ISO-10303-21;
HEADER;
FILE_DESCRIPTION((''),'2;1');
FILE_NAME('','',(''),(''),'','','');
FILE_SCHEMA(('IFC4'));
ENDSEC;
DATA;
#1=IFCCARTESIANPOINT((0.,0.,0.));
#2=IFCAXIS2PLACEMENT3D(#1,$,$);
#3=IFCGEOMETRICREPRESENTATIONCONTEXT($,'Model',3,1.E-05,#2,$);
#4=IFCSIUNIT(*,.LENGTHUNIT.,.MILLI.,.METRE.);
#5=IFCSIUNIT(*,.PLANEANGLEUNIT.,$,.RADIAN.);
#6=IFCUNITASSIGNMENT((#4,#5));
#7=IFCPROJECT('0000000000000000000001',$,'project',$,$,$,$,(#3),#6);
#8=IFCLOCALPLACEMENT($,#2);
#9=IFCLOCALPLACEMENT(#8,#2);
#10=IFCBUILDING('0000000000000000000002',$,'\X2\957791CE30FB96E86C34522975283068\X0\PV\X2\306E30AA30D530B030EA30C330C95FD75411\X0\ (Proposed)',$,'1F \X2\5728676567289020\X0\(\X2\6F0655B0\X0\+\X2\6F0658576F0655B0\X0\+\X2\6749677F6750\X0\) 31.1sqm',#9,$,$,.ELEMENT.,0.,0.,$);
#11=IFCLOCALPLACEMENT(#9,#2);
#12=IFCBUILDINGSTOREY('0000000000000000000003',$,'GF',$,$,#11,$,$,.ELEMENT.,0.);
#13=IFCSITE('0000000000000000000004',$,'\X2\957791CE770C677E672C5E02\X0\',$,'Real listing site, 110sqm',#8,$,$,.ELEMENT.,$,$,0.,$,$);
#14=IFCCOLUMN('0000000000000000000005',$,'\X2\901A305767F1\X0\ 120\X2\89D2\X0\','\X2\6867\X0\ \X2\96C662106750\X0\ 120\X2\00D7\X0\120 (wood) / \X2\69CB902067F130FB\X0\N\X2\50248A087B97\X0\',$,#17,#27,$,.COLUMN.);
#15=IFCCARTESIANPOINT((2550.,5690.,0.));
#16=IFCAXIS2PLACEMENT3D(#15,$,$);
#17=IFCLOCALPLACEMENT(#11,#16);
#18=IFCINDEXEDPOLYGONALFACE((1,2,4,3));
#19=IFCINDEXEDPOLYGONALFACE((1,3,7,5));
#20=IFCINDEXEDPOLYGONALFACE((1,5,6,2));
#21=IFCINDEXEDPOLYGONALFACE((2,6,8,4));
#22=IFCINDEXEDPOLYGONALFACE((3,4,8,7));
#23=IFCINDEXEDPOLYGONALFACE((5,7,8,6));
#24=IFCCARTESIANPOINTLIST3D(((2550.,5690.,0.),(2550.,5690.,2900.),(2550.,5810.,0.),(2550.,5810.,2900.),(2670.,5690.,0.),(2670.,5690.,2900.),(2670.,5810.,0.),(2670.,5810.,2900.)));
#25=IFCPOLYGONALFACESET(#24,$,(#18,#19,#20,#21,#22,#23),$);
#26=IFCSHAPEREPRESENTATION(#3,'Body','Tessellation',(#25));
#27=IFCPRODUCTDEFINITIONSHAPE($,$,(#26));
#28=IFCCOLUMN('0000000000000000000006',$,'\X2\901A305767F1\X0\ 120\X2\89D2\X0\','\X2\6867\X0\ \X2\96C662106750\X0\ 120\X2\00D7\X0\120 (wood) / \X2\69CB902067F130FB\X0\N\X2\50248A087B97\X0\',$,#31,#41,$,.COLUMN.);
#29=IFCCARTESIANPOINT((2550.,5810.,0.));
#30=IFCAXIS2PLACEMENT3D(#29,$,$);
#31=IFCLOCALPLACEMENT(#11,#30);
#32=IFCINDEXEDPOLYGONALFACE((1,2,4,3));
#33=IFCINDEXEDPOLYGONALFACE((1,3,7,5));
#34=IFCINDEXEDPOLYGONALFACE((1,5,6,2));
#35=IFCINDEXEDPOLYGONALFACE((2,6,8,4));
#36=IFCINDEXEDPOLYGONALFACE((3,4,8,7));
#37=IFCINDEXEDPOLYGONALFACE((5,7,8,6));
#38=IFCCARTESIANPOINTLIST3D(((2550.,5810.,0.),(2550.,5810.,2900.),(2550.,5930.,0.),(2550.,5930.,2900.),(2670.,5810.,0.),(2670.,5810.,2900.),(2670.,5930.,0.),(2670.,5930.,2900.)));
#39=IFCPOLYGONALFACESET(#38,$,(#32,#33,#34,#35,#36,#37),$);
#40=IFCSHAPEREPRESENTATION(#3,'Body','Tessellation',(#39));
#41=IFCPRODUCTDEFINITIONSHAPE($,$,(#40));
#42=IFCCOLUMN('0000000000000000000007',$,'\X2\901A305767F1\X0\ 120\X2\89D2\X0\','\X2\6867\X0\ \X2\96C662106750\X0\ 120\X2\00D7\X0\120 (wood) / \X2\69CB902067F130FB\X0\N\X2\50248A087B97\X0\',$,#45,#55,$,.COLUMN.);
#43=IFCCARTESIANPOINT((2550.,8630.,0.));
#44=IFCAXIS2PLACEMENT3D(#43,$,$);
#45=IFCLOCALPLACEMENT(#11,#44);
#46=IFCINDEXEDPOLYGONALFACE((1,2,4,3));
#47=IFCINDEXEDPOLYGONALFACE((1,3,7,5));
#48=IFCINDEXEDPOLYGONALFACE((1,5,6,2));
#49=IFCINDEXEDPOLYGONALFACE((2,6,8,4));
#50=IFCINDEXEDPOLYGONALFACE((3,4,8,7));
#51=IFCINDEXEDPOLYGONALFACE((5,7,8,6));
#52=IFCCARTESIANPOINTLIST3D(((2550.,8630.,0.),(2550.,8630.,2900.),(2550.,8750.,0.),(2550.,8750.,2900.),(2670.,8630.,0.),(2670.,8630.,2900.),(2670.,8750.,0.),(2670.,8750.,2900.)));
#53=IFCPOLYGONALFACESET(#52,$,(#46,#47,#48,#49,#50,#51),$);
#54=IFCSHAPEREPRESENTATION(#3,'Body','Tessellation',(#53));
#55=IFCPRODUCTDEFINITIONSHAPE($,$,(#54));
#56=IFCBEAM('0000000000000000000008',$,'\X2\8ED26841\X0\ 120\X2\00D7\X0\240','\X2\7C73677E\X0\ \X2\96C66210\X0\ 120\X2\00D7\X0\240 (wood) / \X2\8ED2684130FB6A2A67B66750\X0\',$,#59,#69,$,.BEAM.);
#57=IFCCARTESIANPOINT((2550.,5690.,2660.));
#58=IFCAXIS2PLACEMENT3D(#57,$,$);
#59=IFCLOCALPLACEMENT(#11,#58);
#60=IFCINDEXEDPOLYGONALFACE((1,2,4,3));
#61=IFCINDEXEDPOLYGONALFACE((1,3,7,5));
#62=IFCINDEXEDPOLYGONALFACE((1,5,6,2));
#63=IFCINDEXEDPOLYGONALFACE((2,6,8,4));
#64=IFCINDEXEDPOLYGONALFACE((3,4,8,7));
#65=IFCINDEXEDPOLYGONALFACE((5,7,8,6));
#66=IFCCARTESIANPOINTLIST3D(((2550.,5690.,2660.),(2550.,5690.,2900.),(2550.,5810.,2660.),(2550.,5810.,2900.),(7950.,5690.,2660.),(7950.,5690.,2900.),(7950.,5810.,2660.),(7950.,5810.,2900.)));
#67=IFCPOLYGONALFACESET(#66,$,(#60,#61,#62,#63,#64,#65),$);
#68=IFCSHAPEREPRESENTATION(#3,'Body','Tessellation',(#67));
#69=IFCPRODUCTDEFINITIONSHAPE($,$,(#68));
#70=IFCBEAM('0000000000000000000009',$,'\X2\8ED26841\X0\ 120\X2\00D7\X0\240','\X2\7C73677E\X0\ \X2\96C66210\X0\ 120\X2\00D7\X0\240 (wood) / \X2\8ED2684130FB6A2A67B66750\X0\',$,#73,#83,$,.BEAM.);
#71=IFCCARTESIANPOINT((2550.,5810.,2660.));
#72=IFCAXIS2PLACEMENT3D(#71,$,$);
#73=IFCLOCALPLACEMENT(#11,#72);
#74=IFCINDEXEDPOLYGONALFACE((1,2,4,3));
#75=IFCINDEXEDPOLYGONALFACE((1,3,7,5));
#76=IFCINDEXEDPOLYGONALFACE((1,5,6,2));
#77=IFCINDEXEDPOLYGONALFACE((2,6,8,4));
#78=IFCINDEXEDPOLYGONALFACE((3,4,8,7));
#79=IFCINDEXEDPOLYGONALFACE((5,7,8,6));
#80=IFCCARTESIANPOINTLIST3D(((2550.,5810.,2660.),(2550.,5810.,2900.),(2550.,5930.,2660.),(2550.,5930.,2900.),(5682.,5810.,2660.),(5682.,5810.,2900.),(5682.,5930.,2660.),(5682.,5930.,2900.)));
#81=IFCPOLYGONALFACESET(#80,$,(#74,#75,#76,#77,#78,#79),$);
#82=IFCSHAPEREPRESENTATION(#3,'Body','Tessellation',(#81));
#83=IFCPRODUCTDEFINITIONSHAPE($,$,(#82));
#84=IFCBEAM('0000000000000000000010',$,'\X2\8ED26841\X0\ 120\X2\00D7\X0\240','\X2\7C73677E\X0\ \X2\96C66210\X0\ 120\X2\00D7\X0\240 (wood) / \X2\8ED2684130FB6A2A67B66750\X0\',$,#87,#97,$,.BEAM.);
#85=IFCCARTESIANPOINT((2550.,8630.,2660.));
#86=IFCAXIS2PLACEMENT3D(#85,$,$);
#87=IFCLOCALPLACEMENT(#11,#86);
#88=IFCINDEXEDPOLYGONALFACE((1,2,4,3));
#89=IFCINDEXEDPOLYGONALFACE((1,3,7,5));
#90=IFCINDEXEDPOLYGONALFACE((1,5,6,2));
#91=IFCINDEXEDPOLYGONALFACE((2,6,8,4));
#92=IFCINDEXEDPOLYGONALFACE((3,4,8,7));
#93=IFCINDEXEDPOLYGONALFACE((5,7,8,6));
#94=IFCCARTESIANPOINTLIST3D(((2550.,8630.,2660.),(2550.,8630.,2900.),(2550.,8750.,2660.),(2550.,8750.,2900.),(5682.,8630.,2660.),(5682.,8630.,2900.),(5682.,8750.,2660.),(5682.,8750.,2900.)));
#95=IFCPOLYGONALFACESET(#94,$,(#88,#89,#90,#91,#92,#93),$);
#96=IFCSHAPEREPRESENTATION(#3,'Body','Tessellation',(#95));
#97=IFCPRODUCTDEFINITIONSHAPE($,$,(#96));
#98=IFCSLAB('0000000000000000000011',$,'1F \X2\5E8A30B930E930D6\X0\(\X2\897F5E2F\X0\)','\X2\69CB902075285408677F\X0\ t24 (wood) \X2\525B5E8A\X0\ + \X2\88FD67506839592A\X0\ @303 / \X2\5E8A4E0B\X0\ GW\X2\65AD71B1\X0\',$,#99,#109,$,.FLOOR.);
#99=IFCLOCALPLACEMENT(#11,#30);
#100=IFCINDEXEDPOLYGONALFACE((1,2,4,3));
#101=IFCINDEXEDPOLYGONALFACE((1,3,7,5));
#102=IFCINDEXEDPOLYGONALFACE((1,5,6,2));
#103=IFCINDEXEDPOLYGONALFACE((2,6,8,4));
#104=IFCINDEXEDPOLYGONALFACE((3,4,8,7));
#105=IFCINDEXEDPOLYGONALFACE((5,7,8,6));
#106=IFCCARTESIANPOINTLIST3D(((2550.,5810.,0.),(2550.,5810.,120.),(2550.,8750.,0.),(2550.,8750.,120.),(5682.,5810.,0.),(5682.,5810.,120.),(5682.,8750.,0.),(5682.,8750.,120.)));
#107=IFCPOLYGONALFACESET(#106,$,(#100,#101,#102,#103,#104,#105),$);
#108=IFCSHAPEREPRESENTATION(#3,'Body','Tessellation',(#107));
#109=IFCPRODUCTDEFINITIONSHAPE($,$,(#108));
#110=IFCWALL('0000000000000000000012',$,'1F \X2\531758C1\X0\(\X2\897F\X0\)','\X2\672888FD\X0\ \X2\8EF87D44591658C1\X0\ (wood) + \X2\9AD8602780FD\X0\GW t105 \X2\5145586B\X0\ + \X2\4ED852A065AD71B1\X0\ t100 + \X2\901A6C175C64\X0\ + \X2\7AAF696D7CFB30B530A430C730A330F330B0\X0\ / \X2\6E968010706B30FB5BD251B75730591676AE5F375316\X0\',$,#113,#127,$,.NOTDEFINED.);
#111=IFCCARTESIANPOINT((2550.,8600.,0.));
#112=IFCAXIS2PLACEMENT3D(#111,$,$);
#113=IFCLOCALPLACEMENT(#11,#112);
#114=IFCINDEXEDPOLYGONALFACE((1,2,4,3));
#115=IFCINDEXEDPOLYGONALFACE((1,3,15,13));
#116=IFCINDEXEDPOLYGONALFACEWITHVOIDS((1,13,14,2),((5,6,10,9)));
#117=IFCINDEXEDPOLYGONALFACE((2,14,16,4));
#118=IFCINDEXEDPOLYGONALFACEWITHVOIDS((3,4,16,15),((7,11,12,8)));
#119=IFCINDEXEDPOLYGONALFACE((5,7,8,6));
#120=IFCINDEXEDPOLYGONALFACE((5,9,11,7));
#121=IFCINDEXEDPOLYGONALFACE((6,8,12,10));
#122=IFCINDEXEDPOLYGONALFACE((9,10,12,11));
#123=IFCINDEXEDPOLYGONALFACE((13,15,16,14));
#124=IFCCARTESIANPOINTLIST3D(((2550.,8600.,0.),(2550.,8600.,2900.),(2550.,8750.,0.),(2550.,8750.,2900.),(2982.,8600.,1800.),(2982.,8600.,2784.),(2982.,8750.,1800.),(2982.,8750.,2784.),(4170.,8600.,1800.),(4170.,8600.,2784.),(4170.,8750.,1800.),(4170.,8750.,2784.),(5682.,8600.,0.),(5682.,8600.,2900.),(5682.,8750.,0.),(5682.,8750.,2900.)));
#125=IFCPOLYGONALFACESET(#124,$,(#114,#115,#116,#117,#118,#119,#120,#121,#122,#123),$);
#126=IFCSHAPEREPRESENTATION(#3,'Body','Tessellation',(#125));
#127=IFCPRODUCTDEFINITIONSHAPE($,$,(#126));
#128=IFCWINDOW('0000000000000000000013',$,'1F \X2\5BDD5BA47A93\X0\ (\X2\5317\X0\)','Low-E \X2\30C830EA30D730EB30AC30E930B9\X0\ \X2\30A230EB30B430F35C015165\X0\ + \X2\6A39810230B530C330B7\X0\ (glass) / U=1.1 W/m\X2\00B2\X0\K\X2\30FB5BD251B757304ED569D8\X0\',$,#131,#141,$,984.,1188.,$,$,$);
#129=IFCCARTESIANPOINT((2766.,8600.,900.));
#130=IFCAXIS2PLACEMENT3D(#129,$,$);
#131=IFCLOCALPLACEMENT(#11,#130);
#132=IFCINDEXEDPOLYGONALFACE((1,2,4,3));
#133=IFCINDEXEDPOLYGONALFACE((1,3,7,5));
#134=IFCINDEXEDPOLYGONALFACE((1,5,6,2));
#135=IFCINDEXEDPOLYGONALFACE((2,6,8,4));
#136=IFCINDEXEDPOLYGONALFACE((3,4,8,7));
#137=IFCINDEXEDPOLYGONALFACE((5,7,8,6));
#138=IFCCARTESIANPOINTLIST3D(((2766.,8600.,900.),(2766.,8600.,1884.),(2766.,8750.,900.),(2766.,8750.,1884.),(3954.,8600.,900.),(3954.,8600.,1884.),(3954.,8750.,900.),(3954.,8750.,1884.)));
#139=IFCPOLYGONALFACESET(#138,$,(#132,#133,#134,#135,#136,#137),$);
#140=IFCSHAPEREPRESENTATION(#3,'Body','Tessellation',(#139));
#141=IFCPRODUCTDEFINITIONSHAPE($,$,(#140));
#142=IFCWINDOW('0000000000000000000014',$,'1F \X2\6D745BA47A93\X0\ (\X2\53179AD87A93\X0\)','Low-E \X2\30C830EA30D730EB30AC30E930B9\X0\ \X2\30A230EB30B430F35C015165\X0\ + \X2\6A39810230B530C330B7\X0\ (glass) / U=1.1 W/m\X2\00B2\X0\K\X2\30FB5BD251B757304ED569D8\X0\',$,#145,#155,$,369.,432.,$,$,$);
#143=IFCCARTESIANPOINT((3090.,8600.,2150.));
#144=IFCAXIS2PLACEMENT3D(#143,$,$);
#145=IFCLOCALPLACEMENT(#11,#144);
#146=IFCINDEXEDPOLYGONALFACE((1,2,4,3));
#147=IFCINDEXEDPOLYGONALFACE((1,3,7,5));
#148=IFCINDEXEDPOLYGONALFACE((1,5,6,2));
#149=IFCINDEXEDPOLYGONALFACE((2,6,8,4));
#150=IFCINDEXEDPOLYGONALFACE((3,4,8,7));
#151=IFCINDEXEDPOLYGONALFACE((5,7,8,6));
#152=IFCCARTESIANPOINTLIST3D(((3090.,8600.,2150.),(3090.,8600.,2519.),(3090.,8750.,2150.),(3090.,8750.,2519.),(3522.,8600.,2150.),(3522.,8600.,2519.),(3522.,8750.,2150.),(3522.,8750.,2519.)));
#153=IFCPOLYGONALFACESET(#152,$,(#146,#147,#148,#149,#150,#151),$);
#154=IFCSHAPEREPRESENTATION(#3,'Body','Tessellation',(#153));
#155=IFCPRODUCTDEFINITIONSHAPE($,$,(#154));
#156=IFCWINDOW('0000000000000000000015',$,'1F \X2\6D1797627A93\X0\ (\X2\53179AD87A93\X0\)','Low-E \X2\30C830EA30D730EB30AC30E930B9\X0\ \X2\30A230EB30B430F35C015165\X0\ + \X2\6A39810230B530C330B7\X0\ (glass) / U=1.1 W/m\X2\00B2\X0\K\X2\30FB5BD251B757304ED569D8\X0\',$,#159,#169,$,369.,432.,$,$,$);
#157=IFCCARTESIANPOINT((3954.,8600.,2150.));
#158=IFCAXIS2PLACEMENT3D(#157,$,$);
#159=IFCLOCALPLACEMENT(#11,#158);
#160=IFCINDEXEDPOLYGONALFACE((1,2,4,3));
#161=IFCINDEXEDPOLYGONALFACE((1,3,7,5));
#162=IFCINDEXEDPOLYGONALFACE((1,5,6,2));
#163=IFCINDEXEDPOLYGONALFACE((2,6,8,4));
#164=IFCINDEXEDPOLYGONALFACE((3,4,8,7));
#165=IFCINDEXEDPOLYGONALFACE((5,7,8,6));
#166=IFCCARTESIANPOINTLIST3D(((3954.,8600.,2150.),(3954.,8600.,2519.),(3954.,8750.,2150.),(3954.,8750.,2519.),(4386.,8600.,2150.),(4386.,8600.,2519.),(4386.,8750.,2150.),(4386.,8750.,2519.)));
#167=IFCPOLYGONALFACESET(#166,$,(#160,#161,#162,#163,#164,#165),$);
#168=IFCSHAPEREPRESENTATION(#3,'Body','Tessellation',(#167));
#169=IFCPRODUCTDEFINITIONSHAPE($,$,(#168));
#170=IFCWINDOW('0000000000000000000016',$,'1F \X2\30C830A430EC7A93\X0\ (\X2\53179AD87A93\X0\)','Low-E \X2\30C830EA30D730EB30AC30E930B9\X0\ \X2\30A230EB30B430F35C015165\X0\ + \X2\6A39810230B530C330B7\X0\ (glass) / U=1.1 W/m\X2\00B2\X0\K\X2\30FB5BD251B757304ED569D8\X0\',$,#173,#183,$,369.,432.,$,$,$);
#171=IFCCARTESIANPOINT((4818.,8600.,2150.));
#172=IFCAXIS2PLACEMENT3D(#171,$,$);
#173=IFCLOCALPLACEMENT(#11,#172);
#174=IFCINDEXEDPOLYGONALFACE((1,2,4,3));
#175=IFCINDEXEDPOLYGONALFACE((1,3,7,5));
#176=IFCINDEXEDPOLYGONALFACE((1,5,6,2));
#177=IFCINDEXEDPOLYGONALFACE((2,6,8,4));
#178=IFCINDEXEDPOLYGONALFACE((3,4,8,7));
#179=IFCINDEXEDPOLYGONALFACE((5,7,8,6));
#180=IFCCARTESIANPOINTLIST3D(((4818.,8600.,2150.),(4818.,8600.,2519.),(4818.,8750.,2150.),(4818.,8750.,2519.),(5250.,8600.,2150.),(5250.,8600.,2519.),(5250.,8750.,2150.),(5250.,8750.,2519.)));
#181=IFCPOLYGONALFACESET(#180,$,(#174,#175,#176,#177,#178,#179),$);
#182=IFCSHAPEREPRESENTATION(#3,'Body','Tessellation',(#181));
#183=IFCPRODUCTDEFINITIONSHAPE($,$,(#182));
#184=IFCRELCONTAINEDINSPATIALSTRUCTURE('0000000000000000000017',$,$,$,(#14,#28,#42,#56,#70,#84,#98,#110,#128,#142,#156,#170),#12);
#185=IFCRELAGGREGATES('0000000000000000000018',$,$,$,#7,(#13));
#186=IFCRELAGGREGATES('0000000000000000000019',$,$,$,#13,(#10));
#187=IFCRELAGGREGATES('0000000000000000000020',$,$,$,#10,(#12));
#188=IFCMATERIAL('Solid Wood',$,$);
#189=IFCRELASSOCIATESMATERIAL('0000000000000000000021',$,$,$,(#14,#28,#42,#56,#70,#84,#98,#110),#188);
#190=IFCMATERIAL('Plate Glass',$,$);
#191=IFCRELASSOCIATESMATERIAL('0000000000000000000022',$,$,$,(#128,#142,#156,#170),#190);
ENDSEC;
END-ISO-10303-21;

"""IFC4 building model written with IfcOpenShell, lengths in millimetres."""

from ifc_helpers import new_model, si_unit, frame, frame_2d, origin, place, context, project, spatial, rectangle, extrude, material, element, fill, save


model = new_model("IFC4")

# Units and contexts
model_context = context("Model", 3, precision=1e-05, world=origin())
ifc_project = project(units=[si_unit("LENGTHUNIT", "METRE", prefix="MILLI"), si_unit("PLANEANGLEUNIT", "RADIAN")], contexts=[model_context])

# Site, building, storey
site_placement = place(None, origin())
site = spatial("IfcSite", under=ifc_project, at=site_placement, Name="長野県松本市", ObjectType="Real listing site, 110sqm", CompositionType="ELEMENT", RefElevation=0.0)
building_placement = place(site_placement, origin())
building = spatial("IfcBuilding", under=site, at=building_placement, Name="長野・雨水利用とPVのオフグリッド志向 (Proposed)", ObjectType="1F 在来木造(漆喰+漆塗漆喰+杉板材) 31.1sqm", CompositionType="ELEMENT", ElevationOfRefHeight=0.0, ElevationOfTerrain=0.0)
storey_placement = place(building_placement, origin())
storey = spatial("IfcBuildingStorey", under=building, at=storey_placement, Name="GF", CompositionType="ELEMENT", Elevation=0.0)

# Columns
ifc_material_1 = material(Name="Solid Wood")
column_1_placement = place(storey_placement, frame((2550.0, 5690.0, 0.0)))
element("IfcColumn", 1, at=column_1_placement, inside=storey, material=ifc_material_1, Name="通し柱 120角", Description="桧 集成材 120×120 (wood) / 構造柱・N値計算", PredefinedType="COLUMN", context=model_context, shape_type="SweptSolid", body=[
    extrude(rectangle(XDim=120.0, YDim=120.0, at=frame_2d((60.0, 60.0))), frame((2550.0, 5690.0, 0.0)), (0.0, 0.0, 1.0), 2900.0),
])
column_2_placement = place(storey_placement, frame((2550.0, 5810.0, 0.0)))
element("IfcColumn", 2, at=column_2_placement, inside=storey, material=ifc_material_1, Name="通し柱 120角", Description="桧 集成材 120×120 (wood) / 構造柱・N値計算", PredefinedType="COLUMN", context=model_context, shape_type="SweptSolid", body=[
    extrude(rectangle(XDim=120.0, YDim=120.0, at=frame_2d((60.0, 60.0))), frame((2550.0, 5810.0, 0.0)), (0.0, 0.0, 1.0), 2900.0),
])
column_3_placement = place(storey_placement, frame((2550.0, 8630.0, 0.0)))
element("IfcColumn", 3, at=column_3_placement, inside=storey, material=ifc_material_1, Name="通し柱 120角", Description="桧 集成材 120×120 (wood) / 構造柱・N値計算", PredefinedType="COLUMN", context=model_context, shape_type="SweptSolid", body=[
    extrude(rectangle(XDim=120.0, YDim=120.0, at=frame_2d((60.0, 60.0))), frame((2550.0, 8630.0, 0.0)), (0.0, 0.0, 1.0), 2900.0),
])

# Beams
beam_1_placement = place(storey_placement, frame((2550.0, 5690.0, 2660.0)))
element("IfcBeam", 4, at=beam_1_placement, inside=storey, material=ifc_material_1, Name="軒桁 120×240", Description="米松 集成 120×240 (wood) / 軒桁・横架材", PredefinedType="BEAM", context=model_context, shape_type="SweptSolid", body=[
    extrude(rectangle(XDim=5400.0, YDim=120.0, at=frame_2d((2700.0, 60.0))), frame((2550.0, 5690.0, 2660.0)), (0.0, 0.0, 1.0), 240.0),
])
beam_2_placement = place(storey_placement, frame((2550.0, 5810.0, 2660.0)))
element("IfcBeam", 5, at=beam_2_placement, inside=storey, material=ifc_material_1, Name="軒桁 120×240", Description="米松 集成 120×240 (wood) / 軒桁・横架材", PredefinedType="BEAM", context=model_context, shape_type="SweptSolid", body=[
    extrude(rectangle(XDim=3132.0, YDim=120.0, at=frame_2d((1566.0, 60.0))), frame((2550.0, 5810.0, 2660.0)), (0.0, 0.0, 1.0), 240.0),
])
beam_3_placement = place(storey_placement, frame((2550.0, 8630.0, 2660.0)))
element("IfcBeam", 6, at=beam_3_placement, inside=storey, material=ifc_material_1, Name="軒桁 120×240", Description="米松 集成 120×240 (wood) / 軒桁・横架材", PredefinedType="BEAM", context=model_context, shape_type="SweptSolid", body=[
    extrude(rectangle(XDim=3132.0, YDim=120.0, at=frame_2d((1566.0, 60.0))), frame((2550.0, 8630.0, 2660.0)), (0.0, 0.0, 1.0), 240.0),
])

# Slab
slab_placement = place(storey_placement, frame((2550.0, 5810.0, 0.0)))
element("IfcSlab", 7, at=slab_placement, inside=storey, material=ifc_material_1, Name="1F 床スラブ(西帯)", Description="構造用合板 t24 (wood) 剛床 + 製材根太 @303 / 床下 GW断熱", PredefinedType="FLOOR", context=model_context, shape_type="SweptSolid", body=[
    extrude(rectangle(XDim=3132.0, YDim=2940.0, at=frame_2d((1566.0, 1470.0))), frame((2550.0, 5810.0, 0.0)), (0.0, 0.0, 1.0), 120.0),
])

# Wall, openings, windows
wall_1_placement = place(storey_placement, frame((2550.0, 8600.0, 0.0)))
wall_1 = element("IfcWall", 8, at=wall_1_placement, inside=storey, material=ifc_material_1, Name="1F 北壁(西)", Description="木製 軸組外壁 (wood) + 高性能GW t105 充填 + 付加断熱 t100 + 通気層 + 窯業系サイディング / 準耐火・寒冷地外皮強化", PredefinedType="NOTDEFINED", context=model_context, shape_type="SweptSolid", body=[
    extrude(rectangle(XDim=3132.0, YDim=150.0, at=frame_2d((1566.0, 75.0))), frame((2550.0, 8600.0, 0.0)), (0.0, 0.0, 1.0), 2900.0),
])
opening_1_placement = place(storey_placement, frame((2766.0, 8600.0, 900.0)))
opening_1 = element("IfcOpeningElement", 9, at=opening_1_placement, cuts=wall_1, PredefinedType="NOTDEFINED", context=model_context, shape_type="SweptSolid", body=[
    extrude(rectangle(XDim=1188.0, YDim=150.0, at=frame_2d((594.0, 75.0))), frame((2766.0, 8600.0, 900.0)), (0.0, 0.0, 1.0), 984.0),
])
opening_2_placement = place(storey_placement, frame((3090.0, 8600.0, 2150.0)))
opening_2 = element("IfcOpeningElement", 10, at=opening_2_placement, cuts=wall_1, PredefinedType="NOTDEFINED", context=model_context, shape_type="SweptSolid", body=[
    extrude(rectangle(XDim=432.0, YDim=150.0, at=frame_2d((216.0, 75.0))), frame((3090.0, 8600.0, 2150.0)), (0.0, 0.0, 1.0), 369.0),
])
opening_3_placement = place(storey_placement, frame((3954.0, 8600.0, 2150.0)))
opening_3 = element("IfcOpeningElement", 11, at=opening_3_placement, cuts=wall_1, PredefinedType="NOTDEFINED", context=model_context, shape_type="SweptSolid", body=[
    extrude(rectangle(XDim=432.0, YDim=150.0, at=frame_2d((216.0, 75.0))), frame((3954.0, 8600.0, 2150.0)), (0.0, 0.0, 1.0), 369.0),
])
opening_4_placement = place(storey_placement, frame((4818.0, 8600.0, 2150.0)))
opening_4 = element("IfcOpeningElement", 12, at=opening_4_placement, cuts=wall_1, PredefinedType="NOTDEFINED", context=model_context, shape_type="SweptSolid", body=[
    extrude(rectangle(XDim=432.0, YDim=150.0, at=frame_2d((216.0, 75.0))), frame((4818.0, 8600.0, 2150.0)), (0.0, 0.0, 1.0), 369.0),
])
ifc_material_2 = material(Name="Plate Glass")
window_1_placement = place(storey_placement, frame((2766.0, 8600.0, 900.0)))
window_1 = element("IfcWindow", 13, at=window_1_placement, inside=storey, material=ifc_material_2, Name="1F 寝室窓 (北)", Description="Low-E トリプルガラス アルゴン封入 + 樹脂サッシ (glass) / U=1.1 W/m²K・寒冷地仕様", OverallHeight=984.0, OverallWidth=1188.0, context=model_context, shape_type="SweptSolid", body=[
    extrude(rectangle(XDim=1188.0, YDim=150.0, at=frame_2d((594.0, 75.0))), frame((2766.0, 8600.0, 900.0)), (0.0, 0.0, 1.0), 984.0),
])
fill(opening_1, window_1)
window_2_placement = place(storey_placement, frame((3090.0, 8600.0, 2150.0)))
window_2 = element("IfcWindow", 14, at=window_2_placement, inside=storey, material=ifc_material_2, Name="1F 浴室窓 (北高窓)", Description="Low-E トリプルガラス アルゴン封入 + 樹脂サッシ (glass) / U=1.1 W/m²K・寒冷地仕様", OverallHeight=369.0, OverallWidth=432.0, context=model_context, shape_type="SweptSolid", body=[
    extrude(rectangle(XDim=432.0, YDim=150.0, at=frame_2d((216.0, 75.0))), frame((3090.0, 8600.0, 2150.0)), (0.0, 0.0, 1.0), 369.0),
])
fill(opening_2, window_2)
window_3_placement = place(storey_placement, frame((3954.0, 8600.0, 2150.0)))
window_3 = element("IfcWindow", 15, at=window_3_placement, inside=storey, material=ifc_material_2, Name="1F 洗面窓 (北高窓)", Description="Low-E トリプルガラス アルゴン封入 + 樹脂サッシ (glass) / U=1.1 W/m²K・寒冷地仕様", OverallHeight=369.0, OverallWidth=432.0, context=model_context, shape_type="SweptSolid", body=[
    extrude(rectangle(XDim=432.0, YDim=150.0, at=frame_2d((216.0, 75.0))), frame((3954.0, 8600.0, 2150.0)), (0.0, 0.0, 1.0), 369.0),
])
fill(opening_3, window_3)
window_4_placement = place(storey_placement, frame((4818.0, 8600.0, 2150.0)))
window_4 = element("IfcWindow", 16, at=window_4_placement, inside=storey, material=ifc_material_2, Name="1F トイレ窓 (北高窓)", Description="Low-E トリプルガラス アルゴン封入 + 樹脂サッシ (glass) / U=1.1 W/m²K・寒冷地仕様", OverallHeight=369.0, OverallWidth=432.0, context=model_context, shape_type="SweptSolid", body=[
    extrude(rectangle(XDim=432.0, YDim=150.0, at=frame_2d((216.0, 75.0))), frame((4818.0, 8600.0, 2150.0)), (0.0, 0.0, 1.0), 369.0),
])
fill(opening_4, window_4)

save(model, "model.ifc")
